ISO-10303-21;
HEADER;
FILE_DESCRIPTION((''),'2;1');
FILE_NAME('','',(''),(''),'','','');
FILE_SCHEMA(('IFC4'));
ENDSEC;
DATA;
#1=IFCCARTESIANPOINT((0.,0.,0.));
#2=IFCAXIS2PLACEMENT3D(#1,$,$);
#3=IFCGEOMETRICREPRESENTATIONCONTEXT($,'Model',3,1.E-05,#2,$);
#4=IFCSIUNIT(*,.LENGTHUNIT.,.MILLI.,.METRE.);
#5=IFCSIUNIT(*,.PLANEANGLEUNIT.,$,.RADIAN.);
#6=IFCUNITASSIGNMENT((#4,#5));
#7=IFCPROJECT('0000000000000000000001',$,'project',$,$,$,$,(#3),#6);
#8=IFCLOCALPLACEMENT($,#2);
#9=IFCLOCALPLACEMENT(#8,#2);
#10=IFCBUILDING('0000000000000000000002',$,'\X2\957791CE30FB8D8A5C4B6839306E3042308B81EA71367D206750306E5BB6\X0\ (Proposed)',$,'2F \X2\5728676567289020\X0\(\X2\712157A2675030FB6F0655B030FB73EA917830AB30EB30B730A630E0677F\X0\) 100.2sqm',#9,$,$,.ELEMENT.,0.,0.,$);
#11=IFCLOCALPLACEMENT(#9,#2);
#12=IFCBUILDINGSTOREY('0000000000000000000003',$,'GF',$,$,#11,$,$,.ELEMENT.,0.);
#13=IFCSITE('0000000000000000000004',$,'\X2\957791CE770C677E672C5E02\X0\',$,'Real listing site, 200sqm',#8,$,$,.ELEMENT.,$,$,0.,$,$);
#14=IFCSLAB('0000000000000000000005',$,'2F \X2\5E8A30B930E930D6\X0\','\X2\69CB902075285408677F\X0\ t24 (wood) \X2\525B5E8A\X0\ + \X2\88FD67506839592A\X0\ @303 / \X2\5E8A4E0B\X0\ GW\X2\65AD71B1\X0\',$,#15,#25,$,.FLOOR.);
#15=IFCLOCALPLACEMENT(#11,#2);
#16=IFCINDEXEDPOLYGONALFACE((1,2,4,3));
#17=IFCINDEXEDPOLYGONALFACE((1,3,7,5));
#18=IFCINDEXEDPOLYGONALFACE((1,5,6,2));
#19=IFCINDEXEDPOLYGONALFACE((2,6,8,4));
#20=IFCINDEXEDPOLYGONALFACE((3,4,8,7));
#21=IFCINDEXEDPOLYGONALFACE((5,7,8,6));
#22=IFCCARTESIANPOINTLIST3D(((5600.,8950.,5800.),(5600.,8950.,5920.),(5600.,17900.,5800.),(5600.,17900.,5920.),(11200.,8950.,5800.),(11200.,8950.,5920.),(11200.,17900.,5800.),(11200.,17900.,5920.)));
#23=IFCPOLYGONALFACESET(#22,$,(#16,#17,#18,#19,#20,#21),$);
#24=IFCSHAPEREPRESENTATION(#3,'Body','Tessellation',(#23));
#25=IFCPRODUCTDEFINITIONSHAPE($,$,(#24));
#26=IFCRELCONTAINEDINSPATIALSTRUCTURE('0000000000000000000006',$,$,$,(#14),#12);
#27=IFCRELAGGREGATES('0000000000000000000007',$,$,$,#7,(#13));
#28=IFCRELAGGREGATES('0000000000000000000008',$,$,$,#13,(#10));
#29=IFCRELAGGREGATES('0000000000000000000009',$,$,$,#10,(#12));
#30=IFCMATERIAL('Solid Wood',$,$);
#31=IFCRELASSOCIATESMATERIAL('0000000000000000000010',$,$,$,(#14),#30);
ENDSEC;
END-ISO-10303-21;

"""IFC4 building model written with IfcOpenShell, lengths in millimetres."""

from ifc_helpers import new_model, si_unit, frame, frame_2d, origin, place, context, project, spatial, rectangle, extrude, material, element, save


model = new_model("IFC4")

# Units and contexts
model_context = context("Model", 3, precision=1e-05, world=origin())
ifc_project = project(units=[si_unit("LENGTHUNIT", "METRE", prefix="MILLI"), si_unit("PLANEANGLEUNIT", "RADIAN")], contexts=[model_context])

# Site, building, storey
site_placement = place(None, origin())
site = spatial("IfcSite", under=ifc_project, at=site_placement, Name="長野県松本市", ObjectType="Real listing site, 200sqm", CompositionType="ELEMENT", RefElevation=0.0)
building_placement = place(site_placement, origin())
building = spatial("IfcBuilding", under=site, at=building_placement, Name="長野・越屋根のある自然素材の家 (Proposed)", ObjectType="2F 在来木造(無垢材・漆喰・珪酸カルシウム板) 100.2sqm", CompositionType="ELEMENT", ElevationOfRefHeight=0.0, ElevationOfTerrain=0.0)
storey_placement = place(building_placement, origin())
storey = spatial("IfcBuildingStorey", under=building, at=storey_placement, Name="GF", CompositionType="ELEMENT", Elevation=0.0)

# Shared definitions
ifc_material_1 = material(Name="Solid Wood")

# Slab
slab_placement = place(storey_placement, frame((2800.0, 4475.0, 2900.0)))
element("IfcSlab", 1, at=slab_placement, inside=storey, material=ifc_material_1, Name="2F 床スラブ", Description="構造用合板 t24 (wood) 剛床 + 製材根太 @303 / 床下 GW断熱", PredefinedType="FLOOR", context=model_context, shape_type="SweptSolid", body=[
    extrude(rectangle(XDim=5600.0, YDim=8950.0, at=frame_2d((2800.0, 4475.0))), frame((2800.0, 4475.0, 2900.0)), (0.0, 0.0, 1.0), 120.0),
])

save(model, "model.ifc")
